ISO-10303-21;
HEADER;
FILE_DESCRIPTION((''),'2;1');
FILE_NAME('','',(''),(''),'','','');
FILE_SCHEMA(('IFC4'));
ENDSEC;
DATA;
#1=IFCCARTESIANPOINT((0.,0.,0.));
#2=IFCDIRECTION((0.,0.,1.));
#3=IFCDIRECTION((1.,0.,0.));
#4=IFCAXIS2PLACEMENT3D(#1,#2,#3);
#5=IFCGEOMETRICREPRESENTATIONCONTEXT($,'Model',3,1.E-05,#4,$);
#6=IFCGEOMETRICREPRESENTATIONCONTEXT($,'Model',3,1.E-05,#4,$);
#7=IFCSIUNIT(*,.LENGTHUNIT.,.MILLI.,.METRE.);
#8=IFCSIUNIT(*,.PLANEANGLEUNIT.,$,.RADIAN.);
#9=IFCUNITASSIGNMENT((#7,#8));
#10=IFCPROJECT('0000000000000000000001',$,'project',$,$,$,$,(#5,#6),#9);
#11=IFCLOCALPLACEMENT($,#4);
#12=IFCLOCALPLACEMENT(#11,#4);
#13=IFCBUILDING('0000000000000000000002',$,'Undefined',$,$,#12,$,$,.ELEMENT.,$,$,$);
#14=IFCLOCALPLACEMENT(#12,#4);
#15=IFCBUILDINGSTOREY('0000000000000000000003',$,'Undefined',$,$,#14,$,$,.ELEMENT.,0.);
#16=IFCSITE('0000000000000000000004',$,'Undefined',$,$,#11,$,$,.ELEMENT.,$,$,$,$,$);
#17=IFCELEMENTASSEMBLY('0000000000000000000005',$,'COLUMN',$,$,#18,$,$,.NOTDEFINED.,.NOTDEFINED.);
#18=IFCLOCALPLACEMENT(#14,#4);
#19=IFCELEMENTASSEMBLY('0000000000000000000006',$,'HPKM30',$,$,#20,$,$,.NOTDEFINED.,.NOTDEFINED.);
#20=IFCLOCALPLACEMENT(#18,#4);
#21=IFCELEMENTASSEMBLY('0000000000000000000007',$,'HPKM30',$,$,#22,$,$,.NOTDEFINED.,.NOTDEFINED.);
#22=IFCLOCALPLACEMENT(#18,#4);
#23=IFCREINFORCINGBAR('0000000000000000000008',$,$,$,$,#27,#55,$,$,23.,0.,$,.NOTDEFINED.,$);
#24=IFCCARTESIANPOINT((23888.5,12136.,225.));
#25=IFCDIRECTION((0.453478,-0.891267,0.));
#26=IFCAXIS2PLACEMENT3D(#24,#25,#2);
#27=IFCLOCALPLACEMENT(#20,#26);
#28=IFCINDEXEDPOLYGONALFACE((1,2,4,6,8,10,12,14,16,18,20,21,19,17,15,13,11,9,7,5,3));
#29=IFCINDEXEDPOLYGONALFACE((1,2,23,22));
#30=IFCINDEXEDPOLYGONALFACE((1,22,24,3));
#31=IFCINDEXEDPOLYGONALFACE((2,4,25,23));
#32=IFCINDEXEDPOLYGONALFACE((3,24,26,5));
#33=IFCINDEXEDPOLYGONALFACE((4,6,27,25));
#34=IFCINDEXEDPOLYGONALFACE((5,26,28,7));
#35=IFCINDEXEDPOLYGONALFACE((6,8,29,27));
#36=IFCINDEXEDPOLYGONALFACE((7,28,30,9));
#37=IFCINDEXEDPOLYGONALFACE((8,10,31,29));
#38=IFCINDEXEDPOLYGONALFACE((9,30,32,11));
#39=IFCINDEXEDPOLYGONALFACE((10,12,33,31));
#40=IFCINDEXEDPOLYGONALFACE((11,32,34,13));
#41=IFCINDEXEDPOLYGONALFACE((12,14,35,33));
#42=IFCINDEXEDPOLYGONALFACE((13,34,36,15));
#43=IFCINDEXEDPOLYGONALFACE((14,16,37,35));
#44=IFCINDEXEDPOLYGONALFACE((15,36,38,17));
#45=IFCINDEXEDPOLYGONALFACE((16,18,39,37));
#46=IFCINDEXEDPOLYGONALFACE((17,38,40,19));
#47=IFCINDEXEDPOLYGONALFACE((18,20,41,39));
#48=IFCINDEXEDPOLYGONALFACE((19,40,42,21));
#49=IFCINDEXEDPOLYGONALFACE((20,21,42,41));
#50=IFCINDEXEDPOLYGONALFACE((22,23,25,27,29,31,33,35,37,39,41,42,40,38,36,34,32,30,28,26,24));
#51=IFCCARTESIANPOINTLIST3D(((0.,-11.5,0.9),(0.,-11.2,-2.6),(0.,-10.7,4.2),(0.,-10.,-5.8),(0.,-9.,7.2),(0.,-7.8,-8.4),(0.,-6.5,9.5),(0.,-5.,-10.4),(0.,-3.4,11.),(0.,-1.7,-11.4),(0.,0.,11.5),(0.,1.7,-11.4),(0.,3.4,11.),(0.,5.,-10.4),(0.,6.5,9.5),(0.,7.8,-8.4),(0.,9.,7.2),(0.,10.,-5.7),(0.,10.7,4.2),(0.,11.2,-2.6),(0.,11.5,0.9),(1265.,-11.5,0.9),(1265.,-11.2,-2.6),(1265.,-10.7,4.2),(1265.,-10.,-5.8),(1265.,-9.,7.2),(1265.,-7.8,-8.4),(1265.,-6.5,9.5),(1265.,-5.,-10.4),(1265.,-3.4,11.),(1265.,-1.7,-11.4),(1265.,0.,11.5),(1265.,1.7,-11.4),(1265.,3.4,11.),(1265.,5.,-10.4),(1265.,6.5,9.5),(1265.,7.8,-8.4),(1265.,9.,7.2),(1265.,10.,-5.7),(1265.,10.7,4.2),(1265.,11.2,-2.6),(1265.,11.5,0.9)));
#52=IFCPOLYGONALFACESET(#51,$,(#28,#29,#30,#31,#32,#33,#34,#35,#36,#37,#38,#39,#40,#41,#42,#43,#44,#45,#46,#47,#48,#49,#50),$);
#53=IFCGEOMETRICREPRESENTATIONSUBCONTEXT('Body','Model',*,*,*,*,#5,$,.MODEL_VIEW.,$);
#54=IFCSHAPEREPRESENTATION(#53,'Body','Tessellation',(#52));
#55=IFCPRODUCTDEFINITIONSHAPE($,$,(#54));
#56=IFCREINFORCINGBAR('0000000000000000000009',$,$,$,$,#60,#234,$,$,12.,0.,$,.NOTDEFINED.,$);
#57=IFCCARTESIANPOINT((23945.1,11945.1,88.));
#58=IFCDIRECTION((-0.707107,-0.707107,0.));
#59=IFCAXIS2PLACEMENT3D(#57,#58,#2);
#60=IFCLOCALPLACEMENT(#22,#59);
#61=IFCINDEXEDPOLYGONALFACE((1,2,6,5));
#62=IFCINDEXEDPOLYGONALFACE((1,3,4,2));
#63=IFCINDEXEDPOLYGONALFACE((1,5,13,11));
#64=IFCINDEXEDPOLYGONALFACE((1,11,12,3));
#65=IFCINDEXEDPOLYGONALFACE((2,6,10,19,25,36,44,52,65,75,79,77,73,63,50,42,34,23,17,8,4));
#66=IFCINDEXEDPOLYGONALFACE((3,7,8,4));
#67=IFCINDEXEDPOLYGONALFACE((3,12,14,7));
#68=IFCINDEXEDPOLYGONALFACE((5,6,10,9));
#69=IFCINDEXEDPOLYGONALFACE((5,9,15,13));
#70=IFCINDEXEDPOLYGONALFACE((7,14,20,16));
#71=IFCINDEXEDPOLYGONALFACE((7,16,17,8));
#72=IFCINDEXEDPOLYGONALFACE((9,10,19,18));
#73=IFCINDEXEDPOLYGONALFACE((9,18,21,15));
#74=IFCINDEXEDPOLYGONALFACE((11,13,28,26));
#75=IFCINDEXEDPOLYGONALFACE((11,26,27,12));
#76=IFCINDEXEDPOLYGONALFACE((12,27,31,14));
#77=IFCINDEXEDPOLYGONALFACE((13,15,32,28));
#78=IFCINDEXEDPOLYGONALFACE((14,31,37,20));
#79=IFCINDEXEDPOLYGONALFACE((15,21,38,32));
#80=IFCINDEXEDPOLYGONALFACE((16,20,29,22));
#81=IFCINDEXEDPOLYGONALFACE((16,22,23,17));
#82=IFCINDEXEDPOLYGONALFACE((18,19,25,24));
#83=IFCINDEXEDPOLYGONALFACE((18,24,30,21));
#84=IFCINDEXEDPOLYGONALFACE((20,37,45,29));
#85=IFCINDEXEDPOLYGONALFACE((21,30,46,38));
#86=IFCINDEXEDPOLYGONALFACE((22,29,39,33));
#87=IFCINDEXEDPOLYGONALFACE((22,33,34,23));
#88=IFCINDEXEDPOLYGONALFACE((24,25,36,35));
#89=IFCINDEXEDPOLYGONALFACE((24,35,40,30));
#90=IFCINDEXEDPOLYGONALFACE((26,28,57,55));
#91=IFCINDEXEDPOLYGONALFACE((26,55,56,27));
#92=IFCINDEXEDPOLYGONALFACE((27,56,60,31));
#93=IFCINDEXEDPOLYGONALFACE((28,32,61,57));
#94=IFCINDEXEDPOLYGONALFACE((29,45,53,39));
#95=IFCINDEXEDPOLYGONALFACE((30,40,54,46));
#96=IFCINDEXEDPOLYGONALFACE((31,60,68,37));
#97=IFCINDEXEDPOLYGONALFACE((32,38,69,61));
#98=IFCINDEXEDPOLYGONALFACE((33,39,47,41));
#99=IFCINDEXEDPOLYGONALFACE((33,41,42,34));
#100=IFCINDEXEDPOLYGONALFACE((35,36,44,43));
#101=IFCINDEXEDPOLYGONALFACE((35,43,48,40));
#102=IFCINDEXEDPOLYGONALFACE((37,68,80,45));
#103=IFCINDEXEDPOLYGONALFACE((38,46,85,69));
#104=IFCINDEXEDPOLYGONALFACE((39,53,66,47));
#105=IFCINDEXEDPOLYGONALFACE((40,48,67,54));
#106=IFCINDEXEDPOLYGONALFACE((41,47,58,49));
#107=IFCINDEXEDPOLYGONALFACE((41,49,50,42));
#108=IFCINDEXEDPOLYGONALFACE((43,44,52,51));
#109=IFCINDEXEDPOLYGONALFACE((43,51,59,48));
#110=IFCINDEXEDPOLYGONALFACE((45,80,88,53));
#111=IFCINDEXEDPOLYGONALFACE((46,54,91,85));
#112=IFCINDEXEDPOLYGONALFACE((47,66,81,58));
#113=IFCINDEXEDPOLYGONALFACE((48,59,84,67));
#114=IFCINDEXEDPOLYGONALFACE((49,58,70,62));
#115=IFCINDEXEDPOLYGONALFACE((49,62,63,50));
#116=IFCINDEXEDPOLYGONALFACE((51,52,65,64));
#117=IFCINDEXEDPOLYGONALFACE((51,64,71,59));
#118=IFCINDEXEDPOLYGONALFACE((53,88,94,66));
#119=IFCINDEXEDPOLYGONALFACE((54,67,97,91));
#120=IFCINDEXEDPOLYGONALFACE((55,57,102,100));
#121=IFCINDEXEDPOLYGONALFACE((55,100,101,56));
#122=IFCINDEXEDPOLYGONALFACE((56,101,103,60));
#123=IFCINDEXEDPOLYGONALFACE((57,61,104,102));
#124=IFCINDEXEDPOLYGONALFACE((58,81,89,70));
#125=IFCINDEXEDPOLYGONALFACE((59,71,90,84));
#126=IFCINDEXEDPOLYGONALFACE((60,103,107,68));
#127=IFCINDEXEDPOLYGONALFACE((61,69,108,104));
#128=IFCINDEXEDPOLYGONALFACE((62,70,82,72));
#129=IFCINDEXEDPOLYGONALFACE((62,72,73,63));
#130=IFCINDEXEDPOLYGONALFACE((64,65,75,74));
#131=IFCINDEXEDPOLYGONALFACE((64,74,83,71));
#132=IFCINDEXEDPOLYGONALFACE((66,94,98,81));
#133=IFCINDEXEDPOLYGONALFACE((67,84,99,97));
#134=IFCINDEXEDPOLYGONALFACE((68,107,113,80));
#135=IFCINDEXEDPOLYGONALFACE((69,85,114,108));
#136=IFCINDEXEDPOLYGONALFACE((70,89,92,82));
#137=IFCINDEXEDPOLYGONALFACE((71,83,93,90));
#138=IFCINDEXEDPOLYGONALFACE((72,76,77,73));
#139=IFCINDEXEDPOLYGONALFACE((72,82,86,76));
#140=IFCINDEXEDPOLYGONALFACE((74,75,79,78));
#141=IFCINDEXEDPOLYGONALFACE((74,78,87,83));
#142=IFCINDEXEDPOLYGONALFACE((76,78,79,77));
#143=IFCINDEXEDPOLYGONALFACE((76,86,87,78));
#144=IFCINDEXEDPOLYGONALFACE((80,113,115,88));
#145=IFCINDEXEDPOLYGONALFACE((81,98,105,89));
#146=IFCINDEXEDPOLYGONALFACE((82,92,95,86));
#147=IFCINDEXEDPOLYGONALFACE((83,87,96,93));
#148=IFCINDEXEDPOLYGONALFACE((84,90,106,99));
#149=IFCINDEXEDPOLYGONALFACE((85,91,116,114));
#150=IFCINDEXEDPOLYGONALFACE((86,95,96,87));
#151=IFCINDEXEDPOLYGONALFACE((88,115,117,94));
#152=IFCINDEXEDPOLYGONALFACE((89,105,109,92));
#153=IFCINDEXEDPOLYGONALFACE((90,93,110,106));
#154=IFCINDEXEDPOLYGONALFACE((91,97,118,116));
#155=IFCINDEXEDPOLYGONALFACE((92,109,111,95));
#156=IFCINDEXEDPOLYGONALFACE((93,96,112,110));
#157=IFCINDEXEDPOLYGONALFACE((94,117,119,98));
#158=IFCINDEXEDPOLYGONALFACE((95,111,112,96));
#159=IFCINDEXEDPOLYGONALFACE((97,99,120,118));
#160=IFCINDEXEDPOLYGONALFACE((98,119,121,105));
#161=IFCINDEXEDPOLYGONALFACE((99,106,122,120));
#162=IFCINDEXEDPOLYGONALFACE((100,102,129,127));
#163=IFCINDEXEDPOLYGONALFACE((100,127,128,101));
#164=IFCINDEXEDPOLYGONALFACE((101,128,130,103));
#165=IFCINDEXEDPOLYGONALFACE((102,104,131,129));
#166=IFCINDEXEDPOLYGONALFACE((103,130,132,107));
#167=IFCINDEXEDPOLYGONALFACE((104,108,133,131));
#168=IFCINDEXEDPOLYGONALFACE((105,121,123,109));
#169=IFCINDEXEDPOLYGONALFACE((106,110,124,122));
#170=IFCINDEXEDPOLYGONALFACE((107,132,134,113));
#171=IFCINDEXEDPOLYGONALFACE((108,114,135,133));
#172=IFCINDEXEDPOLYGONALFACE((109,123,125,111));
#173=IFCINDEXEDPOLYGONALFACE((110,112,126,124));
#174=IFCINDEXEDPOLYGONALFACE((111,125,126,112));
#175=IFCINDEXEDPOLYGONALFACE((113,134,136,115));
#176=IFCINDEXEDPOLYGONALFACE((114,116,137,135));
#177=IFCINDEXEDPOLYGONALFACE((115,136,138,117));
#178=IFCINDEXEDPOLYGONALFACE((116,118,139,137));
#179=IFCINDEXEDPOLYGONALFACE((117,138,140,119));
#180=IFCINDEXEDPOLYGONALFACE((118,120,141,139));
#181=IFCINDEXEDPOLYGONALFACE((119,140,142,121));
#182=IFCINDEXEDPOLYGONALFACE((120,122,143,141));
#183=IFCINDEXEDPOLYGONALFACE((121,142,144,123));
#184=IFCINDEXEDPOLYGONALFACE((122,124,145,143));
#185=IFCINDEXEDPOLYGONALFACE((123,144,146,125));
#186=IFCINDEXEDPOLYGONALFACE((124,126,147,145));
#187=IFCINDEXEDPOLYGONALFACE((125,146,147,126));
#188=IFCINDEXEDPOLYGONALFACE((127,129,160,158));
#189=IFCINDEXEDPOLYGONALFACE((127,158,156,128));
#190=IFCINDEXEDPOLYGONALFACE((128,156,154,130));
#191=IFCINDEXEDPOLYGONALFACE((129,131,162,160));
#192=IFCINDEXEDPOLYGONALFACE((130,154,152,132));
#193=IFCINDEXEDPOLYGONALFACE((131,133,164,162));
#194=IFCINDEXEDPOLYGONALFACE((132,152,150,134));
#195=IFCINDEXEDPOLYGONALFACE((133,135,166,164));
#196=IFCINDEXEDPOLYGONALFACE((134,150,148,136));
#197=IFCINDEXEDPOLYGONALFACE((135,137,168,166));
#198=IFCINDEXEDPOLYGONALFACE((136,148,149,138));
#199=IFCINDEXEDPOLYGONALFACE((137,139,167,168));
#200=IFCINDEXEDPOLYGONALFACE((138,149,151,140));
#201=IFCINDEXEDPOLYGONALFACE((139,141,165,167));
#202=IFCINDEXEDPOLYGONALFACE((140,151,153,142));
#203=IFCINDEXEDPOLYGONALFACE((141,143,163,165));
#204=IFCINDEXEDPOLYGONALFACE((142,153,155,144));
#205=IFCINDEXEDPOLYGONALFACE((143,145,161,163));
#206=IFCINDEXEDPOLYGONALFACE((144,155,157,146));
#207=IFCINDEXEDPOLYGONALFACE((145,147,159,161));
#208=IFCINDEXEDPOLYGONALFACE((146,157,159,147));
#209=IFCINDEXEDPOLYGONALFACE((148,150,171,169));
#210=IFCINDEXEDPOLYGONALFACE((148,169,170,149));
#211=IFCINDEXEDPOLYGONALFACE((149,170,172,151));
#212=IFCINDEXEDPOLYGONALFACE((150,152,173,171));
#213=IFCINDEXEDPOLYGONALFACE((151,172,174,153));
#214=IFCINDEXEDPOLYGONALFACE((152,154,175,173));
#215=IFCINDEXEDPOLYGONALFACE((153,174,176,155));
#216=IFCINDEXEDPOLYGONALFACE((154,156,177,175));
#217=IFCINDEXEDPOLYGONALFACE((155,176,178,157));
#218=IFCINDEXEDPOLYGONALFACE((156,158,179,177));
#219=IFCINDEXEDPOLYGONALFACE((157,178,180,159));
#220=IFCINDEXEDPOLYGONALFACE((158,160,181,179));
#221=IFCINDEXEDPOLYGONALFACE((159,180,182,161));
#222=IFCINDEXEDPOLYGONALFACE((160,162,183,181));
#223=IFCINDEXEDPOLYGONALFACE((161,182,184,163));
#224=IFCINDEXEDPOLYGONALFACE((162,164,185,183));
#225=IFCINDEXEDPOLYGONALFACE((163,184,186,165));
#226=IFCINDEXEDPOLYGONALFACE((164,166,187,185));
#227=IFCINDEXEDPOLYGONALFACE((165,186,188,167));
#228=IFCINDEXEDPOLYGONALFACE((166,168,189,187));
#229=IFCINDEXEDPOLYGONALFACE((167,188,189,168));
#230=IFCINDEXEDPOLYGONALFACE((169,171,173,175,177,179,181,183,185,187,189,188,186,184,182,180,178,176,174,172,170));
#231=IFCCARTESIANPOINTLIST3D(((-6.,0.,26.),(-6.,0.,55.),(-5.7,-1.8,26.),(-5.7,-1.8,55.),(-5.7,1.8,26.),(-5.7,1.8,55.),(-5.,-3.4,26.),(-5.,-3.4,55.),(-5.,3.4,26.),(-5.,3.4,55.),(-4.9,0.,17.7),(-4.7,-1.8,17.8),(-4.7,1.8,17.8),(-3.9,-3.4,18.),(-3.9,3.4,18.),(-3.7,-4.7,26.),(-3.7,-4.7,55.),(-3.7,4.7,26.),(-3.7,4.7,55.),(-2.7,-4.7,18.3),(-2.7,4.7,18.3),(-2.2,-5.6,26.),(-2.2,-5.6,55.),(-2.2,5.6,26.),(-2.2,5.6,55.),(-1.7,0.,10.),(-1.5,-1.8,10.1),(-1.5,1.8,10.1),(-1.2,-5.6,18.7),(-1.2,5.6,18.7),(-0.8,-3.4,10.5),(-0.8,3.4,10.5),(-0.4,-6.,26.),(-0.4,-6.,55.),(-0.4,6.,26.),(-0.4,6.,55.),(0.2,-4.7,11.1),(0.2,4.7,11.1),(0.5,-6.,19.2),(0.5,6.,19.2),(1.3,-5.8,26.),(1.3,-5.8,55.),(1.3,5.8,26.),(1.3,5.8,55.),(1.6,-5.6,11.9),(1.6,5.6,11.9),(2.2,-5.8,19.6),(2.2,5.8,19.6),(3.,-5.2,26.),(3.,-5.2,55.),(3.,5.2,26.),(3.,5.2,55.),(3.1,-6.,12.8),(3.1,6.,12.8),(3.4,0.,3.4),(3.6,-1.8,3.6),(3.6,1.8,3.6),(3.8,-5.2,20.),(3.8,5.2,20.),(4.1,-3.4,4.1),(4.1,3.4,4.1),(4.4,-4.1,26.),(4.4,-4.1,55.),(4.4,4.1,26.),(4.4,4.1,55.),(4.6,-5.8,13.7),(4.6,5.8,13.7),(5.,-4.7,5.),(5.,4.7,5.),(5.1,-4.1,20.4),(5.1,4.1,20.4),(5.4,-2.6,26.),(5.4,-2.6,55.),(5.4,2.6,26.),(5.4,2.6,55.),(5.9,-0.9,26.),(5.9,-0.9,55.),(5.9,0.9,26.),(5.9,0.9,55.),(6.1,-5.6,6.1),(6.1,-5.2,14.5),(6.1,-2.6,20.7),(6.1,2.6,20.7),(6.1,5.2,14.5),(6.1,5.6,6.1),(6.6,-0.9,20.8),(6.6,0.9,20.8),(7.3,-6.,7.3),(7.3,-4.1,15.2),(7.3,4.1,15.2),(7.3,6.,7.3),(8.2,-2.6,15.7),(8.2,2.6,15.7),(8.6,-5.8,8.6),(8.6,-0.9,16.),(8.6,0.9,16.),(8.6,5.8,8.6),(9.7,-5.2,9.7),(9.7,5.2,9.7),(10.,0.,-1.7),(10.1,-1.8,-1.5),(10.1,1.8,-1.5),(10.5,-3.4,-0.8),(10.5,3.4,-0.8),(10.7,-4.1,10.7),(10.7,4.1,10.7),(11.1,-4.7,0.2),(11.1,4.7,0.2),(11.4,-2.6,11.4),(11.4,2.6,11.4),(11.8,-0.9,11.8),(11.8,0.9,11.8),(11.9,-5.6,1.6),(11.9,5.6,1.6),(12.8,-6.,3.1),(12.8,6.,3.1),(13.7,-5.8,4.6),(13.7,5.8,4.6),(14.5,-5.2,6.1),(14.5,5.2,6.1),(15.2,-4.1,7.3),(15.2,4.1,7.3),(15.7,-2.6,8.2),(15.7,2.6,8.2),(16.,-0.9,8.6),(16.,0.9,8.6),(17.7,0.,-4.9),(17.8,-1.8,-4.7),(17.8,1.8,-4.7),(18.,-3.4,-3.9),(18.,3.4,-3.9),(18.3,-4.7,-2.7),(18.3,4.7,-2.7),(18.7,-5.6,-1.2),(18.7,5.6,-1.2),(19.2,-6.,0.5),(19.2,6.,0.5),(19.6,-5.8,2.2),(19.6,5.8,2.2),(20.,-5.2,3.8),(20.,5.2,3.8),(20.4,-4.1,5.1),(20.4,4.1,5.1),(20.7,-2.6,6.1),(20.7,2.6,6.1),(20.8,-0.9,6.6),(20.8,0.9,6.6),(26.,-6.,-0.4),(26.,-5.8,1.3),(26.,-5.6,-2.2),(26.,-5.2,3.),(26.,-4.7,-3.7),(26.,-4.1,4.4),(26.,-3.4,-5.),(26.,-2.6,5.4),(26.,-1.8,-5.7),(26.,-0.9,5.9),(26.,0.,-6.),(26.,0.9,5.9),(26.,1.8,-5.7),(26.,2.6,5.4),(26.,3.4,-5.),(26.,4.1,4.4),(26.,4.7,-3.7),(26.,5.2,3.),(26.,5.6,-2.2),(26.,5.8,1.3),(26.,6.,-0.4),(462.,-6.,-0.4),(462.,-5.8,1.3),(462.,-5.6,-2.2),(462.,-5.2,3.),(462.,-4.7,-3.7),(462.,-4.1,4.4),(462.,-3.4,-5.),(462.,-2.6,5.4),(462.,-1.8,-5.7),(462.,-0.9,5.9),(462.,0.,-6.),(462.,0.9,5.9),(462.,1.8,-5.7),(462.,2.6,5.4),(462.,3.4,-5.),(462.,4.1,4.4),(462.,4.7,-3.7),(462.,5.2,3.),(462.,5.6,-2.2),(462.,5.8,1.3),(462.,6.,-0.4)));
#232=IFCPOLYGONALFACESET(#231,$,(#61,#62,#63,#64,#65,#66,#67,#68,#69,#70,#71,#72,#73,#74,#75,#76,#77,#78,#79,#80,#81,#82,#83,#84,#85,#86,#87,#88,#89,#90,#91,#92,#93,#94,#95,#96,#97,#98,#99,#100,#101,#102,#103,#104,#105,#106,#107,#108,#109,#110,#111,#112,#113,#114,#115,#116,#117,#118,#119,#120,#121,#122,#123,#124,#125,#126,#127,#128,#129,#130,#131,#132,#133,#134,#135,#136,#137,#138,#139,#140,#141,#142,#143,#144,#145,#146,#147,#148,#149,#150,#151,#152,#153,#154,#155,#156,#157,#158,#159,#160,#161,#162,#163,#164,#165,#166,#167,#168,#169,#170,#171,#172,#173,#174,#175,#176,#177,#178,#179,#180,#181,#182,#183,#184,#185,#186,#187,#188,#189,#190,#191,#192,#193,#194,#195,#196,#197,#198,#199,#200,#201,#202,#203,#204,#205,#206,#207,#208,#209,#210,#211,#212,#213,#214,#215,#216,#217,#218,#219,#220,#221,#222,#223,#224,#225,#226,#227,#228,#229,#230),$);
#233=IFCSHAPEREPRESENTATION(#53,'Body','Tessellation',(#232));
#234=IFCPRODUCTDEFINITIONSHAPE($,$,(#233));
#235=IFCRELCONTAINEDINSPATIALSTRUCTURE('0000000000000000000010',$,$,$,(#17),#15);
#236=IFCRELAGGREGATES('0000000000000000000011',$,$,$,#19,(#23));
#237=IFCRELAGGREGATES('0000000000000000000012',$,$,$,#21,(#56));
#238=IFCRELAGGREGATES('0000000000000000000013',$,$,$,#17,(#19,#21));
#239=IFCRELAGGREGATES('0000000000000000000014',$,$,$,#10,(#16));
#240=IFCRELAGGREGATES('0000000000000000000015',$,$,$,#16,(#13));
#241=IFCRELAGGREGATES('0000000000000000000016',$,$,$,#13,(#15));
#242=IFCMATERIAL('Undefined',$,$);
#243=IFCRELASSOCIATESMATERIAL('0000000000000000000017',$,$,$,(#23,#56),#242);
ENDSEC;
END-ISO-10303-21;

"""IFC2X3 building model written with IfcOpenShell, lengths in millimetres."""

from ifc_helpers import new_model, entity, si_unit, frame, origin_with_axes, place, context, subcontext, project, spatial, source, transform, mapped, material, element, aggregate, save


model = new_model("IFC2X3")

# Units and contexts
model_context_1 = context("Model", 3, precision=1e-05, world=origin_with_axes())
model_context_2 = context("Model", 3, precision=1e-05, world=origin_with_axes())
body_context = subcontext(model_context_1, "Body", "Model", "MODEL_VIEW")
ifc_project = project(units=[si_unit("LENGTHUNIT", "METRE", prefix="MILLI"), si_unit("PLANEANGLEUNIT", "RADIAN")], contexts=[model_context_1, model_context_2])

# Site, building, storey
site_placement = place(None, origin_with_axes())
site = spatial("IfcSite", under=ifc_project, at=site_placement, Name="Undefined", CompositionType="ELEMENT")
building_placement = place(site_placement, origin_with_axes())
building = spatial("IfcBuilding", under=site, at=building_placement, Name="Undefined", CompositionType="ELEMENT")
storey_placement = place(building_placement, origin_with_axes())
storey = spatial("IfcBuildingStorey", under=building, at=storey_placement, Name="Undefined", CompositionType="ELEMENT", Elevation=0.0)

# Element assembly
assembly_1_placement = place(storey_placement, origin_with_axes())
assembly_1 = element("IfcElementAssembly", 1, at=assembly_1_placement, inside=storey, Name="COLUMN", AssemblyPlace="NOTDEFINED", PredefinedType="NOTDEFINED")

# Element assemblies
assembly_2_placement = place(assembly_1_placement, origin_with_axes())
assembly_2 = element("IfcElementAssembly", 2, at=assembly_2_placement, Name="HPKM30", AssemblyPlace="NOTDEFINED", PredefinedType="NOTDEFINED")
assembly_3_placement = place(assembly_1_placement, origin_with_axes())
assembly_3 = element("IfcElementAssembly", 3, at=assembly_3_placement, Name="HPKM30", AssemblyPlace="NOTDEFINED", PredefinedType="NOTDEFINED")

# Shared definitions
ifc_material_1 = material(Name="Undefined")

# Reinforcing bars
shared_shape_1 = source(origin_with_axes(), body_context, "Body", "AdvancedSweptSolid", [
    entity("IfcSweptDiskSolid", entity("IfcTrimmedCurve", entity("IfcLine", entity("IfcCartesianPoint", [0.0, 0.0, 0.0]), entity("IfcVector", entity("IfcDirection", [1.0, 0.0, 0.0]), 1.0)), [entity("IfcParameterValue", 0.0)], [entity("IfcParameterValue", 1265.0)], True, "PARAMETER"), 11.5, None, 0.0, 1265.0),
])
reinforcing_bar_1_placement = place(assembly_2_placement, frame((23888.5, 12136.0, 225.0), z_axis=(0.453478, -0.891267, 0.0), x_axis=(0.0, 0.0, 1.0)))
reinforcing_bar_1 = element("IfcReinforcingBar", 4, at=reinforcing_bar_1_placement, material=ifc_material_1, BarRole="NOTDEFINED", CrossSectionArea=0.0, NominalDiameter=23.0, context=body_context, shape_type="MappedRepresentation", body=[
    mapped(shared_shape_1, transform((0.0, 0.0, 0.0))),
])
aggregate(assembly_2, [reinforcing_bar_1])
shared_shape_2 = source(origin_with_axes(), body_context, "Body", "AdvancedSweptSolid", [
    entity("IfcSweptDiskSolid", entity("IfcCompositeCurve", [entity("IfcCompositeCurveSegment", "CONTINUOUS", True, entity("IfcTrimmedCurve", entity("IfcLine", entity("IfcCartesianPoint", [0.0, 0.0, 0.0]), entity("IfcVector", entity("IfcDirection", [0.0, 0.0, -1.0]), 1.0)), [entity("IfcParameterValue", 0.0)], [entity("IfcParameterValue", 29.0)], True, "PARAMETER")), entity("IfcCompositeCurveSegment", "CONTINUOUS", True, entity("IfcTrimmedCurve", entity("IfcCircle", entity("IfcAxis2Placement3D", entity("IfcCartesianPoint", [26.0, 0.0, -29.0]), entity("IfcDirection", [0.0, -1.0, 0.0]), entity("IfcDirection", [-1.0, 0.0, 0.0])), 26.0), [entity("IfcParameterValue", 0.0)], [entity("IfcParameterValue", 1.570796)], True, "PARAMETER")), entity("IfcCompositeCurveSegment", "DISCONTINUOUS", True, entity("IfcTrimmedCurve", entity("IfcLine", entity("IfcCartesianPoint", [26.0, 0.0, -55.0]), entity("IfcVector", entity("IfcDirection", [1.0, 0.0, 0.0]), 1.0)), [entity("IfcParameterValue", 0.0)], [entity("IfcParameterValue", 436.0)], True, "PARAMETER"))], False), 6.0, None, 0.0, 466.6),
])
reinforcing_bar_2_placement = place(assembly_3_placement, frame((23945.1, 11945.1, 88.0), z_axis=(-0.707107, -0.707107, 0.0), x_axis=(0.0, 0.0, 1.0)))
reinforcing_bar_2 = element("IfcReinforcingBar", 5, at=reinforcing_bar_2_placement, material=ifc_material_1, BarRole="NOTDEFINED", CrossSectionArea=0.0, NominalDiameter=12.0, context=body_context, shape_type="MappedRepresentation", body=[
    mapped(shared_shape_2, transform((0.0, 0.0, 55.0))),
])
aggregate(assembly_3, [reinforcing_bar_2])
aggregate(assembly_1, [assembly_2, assembly_3])

save(model, "model.ifc")
